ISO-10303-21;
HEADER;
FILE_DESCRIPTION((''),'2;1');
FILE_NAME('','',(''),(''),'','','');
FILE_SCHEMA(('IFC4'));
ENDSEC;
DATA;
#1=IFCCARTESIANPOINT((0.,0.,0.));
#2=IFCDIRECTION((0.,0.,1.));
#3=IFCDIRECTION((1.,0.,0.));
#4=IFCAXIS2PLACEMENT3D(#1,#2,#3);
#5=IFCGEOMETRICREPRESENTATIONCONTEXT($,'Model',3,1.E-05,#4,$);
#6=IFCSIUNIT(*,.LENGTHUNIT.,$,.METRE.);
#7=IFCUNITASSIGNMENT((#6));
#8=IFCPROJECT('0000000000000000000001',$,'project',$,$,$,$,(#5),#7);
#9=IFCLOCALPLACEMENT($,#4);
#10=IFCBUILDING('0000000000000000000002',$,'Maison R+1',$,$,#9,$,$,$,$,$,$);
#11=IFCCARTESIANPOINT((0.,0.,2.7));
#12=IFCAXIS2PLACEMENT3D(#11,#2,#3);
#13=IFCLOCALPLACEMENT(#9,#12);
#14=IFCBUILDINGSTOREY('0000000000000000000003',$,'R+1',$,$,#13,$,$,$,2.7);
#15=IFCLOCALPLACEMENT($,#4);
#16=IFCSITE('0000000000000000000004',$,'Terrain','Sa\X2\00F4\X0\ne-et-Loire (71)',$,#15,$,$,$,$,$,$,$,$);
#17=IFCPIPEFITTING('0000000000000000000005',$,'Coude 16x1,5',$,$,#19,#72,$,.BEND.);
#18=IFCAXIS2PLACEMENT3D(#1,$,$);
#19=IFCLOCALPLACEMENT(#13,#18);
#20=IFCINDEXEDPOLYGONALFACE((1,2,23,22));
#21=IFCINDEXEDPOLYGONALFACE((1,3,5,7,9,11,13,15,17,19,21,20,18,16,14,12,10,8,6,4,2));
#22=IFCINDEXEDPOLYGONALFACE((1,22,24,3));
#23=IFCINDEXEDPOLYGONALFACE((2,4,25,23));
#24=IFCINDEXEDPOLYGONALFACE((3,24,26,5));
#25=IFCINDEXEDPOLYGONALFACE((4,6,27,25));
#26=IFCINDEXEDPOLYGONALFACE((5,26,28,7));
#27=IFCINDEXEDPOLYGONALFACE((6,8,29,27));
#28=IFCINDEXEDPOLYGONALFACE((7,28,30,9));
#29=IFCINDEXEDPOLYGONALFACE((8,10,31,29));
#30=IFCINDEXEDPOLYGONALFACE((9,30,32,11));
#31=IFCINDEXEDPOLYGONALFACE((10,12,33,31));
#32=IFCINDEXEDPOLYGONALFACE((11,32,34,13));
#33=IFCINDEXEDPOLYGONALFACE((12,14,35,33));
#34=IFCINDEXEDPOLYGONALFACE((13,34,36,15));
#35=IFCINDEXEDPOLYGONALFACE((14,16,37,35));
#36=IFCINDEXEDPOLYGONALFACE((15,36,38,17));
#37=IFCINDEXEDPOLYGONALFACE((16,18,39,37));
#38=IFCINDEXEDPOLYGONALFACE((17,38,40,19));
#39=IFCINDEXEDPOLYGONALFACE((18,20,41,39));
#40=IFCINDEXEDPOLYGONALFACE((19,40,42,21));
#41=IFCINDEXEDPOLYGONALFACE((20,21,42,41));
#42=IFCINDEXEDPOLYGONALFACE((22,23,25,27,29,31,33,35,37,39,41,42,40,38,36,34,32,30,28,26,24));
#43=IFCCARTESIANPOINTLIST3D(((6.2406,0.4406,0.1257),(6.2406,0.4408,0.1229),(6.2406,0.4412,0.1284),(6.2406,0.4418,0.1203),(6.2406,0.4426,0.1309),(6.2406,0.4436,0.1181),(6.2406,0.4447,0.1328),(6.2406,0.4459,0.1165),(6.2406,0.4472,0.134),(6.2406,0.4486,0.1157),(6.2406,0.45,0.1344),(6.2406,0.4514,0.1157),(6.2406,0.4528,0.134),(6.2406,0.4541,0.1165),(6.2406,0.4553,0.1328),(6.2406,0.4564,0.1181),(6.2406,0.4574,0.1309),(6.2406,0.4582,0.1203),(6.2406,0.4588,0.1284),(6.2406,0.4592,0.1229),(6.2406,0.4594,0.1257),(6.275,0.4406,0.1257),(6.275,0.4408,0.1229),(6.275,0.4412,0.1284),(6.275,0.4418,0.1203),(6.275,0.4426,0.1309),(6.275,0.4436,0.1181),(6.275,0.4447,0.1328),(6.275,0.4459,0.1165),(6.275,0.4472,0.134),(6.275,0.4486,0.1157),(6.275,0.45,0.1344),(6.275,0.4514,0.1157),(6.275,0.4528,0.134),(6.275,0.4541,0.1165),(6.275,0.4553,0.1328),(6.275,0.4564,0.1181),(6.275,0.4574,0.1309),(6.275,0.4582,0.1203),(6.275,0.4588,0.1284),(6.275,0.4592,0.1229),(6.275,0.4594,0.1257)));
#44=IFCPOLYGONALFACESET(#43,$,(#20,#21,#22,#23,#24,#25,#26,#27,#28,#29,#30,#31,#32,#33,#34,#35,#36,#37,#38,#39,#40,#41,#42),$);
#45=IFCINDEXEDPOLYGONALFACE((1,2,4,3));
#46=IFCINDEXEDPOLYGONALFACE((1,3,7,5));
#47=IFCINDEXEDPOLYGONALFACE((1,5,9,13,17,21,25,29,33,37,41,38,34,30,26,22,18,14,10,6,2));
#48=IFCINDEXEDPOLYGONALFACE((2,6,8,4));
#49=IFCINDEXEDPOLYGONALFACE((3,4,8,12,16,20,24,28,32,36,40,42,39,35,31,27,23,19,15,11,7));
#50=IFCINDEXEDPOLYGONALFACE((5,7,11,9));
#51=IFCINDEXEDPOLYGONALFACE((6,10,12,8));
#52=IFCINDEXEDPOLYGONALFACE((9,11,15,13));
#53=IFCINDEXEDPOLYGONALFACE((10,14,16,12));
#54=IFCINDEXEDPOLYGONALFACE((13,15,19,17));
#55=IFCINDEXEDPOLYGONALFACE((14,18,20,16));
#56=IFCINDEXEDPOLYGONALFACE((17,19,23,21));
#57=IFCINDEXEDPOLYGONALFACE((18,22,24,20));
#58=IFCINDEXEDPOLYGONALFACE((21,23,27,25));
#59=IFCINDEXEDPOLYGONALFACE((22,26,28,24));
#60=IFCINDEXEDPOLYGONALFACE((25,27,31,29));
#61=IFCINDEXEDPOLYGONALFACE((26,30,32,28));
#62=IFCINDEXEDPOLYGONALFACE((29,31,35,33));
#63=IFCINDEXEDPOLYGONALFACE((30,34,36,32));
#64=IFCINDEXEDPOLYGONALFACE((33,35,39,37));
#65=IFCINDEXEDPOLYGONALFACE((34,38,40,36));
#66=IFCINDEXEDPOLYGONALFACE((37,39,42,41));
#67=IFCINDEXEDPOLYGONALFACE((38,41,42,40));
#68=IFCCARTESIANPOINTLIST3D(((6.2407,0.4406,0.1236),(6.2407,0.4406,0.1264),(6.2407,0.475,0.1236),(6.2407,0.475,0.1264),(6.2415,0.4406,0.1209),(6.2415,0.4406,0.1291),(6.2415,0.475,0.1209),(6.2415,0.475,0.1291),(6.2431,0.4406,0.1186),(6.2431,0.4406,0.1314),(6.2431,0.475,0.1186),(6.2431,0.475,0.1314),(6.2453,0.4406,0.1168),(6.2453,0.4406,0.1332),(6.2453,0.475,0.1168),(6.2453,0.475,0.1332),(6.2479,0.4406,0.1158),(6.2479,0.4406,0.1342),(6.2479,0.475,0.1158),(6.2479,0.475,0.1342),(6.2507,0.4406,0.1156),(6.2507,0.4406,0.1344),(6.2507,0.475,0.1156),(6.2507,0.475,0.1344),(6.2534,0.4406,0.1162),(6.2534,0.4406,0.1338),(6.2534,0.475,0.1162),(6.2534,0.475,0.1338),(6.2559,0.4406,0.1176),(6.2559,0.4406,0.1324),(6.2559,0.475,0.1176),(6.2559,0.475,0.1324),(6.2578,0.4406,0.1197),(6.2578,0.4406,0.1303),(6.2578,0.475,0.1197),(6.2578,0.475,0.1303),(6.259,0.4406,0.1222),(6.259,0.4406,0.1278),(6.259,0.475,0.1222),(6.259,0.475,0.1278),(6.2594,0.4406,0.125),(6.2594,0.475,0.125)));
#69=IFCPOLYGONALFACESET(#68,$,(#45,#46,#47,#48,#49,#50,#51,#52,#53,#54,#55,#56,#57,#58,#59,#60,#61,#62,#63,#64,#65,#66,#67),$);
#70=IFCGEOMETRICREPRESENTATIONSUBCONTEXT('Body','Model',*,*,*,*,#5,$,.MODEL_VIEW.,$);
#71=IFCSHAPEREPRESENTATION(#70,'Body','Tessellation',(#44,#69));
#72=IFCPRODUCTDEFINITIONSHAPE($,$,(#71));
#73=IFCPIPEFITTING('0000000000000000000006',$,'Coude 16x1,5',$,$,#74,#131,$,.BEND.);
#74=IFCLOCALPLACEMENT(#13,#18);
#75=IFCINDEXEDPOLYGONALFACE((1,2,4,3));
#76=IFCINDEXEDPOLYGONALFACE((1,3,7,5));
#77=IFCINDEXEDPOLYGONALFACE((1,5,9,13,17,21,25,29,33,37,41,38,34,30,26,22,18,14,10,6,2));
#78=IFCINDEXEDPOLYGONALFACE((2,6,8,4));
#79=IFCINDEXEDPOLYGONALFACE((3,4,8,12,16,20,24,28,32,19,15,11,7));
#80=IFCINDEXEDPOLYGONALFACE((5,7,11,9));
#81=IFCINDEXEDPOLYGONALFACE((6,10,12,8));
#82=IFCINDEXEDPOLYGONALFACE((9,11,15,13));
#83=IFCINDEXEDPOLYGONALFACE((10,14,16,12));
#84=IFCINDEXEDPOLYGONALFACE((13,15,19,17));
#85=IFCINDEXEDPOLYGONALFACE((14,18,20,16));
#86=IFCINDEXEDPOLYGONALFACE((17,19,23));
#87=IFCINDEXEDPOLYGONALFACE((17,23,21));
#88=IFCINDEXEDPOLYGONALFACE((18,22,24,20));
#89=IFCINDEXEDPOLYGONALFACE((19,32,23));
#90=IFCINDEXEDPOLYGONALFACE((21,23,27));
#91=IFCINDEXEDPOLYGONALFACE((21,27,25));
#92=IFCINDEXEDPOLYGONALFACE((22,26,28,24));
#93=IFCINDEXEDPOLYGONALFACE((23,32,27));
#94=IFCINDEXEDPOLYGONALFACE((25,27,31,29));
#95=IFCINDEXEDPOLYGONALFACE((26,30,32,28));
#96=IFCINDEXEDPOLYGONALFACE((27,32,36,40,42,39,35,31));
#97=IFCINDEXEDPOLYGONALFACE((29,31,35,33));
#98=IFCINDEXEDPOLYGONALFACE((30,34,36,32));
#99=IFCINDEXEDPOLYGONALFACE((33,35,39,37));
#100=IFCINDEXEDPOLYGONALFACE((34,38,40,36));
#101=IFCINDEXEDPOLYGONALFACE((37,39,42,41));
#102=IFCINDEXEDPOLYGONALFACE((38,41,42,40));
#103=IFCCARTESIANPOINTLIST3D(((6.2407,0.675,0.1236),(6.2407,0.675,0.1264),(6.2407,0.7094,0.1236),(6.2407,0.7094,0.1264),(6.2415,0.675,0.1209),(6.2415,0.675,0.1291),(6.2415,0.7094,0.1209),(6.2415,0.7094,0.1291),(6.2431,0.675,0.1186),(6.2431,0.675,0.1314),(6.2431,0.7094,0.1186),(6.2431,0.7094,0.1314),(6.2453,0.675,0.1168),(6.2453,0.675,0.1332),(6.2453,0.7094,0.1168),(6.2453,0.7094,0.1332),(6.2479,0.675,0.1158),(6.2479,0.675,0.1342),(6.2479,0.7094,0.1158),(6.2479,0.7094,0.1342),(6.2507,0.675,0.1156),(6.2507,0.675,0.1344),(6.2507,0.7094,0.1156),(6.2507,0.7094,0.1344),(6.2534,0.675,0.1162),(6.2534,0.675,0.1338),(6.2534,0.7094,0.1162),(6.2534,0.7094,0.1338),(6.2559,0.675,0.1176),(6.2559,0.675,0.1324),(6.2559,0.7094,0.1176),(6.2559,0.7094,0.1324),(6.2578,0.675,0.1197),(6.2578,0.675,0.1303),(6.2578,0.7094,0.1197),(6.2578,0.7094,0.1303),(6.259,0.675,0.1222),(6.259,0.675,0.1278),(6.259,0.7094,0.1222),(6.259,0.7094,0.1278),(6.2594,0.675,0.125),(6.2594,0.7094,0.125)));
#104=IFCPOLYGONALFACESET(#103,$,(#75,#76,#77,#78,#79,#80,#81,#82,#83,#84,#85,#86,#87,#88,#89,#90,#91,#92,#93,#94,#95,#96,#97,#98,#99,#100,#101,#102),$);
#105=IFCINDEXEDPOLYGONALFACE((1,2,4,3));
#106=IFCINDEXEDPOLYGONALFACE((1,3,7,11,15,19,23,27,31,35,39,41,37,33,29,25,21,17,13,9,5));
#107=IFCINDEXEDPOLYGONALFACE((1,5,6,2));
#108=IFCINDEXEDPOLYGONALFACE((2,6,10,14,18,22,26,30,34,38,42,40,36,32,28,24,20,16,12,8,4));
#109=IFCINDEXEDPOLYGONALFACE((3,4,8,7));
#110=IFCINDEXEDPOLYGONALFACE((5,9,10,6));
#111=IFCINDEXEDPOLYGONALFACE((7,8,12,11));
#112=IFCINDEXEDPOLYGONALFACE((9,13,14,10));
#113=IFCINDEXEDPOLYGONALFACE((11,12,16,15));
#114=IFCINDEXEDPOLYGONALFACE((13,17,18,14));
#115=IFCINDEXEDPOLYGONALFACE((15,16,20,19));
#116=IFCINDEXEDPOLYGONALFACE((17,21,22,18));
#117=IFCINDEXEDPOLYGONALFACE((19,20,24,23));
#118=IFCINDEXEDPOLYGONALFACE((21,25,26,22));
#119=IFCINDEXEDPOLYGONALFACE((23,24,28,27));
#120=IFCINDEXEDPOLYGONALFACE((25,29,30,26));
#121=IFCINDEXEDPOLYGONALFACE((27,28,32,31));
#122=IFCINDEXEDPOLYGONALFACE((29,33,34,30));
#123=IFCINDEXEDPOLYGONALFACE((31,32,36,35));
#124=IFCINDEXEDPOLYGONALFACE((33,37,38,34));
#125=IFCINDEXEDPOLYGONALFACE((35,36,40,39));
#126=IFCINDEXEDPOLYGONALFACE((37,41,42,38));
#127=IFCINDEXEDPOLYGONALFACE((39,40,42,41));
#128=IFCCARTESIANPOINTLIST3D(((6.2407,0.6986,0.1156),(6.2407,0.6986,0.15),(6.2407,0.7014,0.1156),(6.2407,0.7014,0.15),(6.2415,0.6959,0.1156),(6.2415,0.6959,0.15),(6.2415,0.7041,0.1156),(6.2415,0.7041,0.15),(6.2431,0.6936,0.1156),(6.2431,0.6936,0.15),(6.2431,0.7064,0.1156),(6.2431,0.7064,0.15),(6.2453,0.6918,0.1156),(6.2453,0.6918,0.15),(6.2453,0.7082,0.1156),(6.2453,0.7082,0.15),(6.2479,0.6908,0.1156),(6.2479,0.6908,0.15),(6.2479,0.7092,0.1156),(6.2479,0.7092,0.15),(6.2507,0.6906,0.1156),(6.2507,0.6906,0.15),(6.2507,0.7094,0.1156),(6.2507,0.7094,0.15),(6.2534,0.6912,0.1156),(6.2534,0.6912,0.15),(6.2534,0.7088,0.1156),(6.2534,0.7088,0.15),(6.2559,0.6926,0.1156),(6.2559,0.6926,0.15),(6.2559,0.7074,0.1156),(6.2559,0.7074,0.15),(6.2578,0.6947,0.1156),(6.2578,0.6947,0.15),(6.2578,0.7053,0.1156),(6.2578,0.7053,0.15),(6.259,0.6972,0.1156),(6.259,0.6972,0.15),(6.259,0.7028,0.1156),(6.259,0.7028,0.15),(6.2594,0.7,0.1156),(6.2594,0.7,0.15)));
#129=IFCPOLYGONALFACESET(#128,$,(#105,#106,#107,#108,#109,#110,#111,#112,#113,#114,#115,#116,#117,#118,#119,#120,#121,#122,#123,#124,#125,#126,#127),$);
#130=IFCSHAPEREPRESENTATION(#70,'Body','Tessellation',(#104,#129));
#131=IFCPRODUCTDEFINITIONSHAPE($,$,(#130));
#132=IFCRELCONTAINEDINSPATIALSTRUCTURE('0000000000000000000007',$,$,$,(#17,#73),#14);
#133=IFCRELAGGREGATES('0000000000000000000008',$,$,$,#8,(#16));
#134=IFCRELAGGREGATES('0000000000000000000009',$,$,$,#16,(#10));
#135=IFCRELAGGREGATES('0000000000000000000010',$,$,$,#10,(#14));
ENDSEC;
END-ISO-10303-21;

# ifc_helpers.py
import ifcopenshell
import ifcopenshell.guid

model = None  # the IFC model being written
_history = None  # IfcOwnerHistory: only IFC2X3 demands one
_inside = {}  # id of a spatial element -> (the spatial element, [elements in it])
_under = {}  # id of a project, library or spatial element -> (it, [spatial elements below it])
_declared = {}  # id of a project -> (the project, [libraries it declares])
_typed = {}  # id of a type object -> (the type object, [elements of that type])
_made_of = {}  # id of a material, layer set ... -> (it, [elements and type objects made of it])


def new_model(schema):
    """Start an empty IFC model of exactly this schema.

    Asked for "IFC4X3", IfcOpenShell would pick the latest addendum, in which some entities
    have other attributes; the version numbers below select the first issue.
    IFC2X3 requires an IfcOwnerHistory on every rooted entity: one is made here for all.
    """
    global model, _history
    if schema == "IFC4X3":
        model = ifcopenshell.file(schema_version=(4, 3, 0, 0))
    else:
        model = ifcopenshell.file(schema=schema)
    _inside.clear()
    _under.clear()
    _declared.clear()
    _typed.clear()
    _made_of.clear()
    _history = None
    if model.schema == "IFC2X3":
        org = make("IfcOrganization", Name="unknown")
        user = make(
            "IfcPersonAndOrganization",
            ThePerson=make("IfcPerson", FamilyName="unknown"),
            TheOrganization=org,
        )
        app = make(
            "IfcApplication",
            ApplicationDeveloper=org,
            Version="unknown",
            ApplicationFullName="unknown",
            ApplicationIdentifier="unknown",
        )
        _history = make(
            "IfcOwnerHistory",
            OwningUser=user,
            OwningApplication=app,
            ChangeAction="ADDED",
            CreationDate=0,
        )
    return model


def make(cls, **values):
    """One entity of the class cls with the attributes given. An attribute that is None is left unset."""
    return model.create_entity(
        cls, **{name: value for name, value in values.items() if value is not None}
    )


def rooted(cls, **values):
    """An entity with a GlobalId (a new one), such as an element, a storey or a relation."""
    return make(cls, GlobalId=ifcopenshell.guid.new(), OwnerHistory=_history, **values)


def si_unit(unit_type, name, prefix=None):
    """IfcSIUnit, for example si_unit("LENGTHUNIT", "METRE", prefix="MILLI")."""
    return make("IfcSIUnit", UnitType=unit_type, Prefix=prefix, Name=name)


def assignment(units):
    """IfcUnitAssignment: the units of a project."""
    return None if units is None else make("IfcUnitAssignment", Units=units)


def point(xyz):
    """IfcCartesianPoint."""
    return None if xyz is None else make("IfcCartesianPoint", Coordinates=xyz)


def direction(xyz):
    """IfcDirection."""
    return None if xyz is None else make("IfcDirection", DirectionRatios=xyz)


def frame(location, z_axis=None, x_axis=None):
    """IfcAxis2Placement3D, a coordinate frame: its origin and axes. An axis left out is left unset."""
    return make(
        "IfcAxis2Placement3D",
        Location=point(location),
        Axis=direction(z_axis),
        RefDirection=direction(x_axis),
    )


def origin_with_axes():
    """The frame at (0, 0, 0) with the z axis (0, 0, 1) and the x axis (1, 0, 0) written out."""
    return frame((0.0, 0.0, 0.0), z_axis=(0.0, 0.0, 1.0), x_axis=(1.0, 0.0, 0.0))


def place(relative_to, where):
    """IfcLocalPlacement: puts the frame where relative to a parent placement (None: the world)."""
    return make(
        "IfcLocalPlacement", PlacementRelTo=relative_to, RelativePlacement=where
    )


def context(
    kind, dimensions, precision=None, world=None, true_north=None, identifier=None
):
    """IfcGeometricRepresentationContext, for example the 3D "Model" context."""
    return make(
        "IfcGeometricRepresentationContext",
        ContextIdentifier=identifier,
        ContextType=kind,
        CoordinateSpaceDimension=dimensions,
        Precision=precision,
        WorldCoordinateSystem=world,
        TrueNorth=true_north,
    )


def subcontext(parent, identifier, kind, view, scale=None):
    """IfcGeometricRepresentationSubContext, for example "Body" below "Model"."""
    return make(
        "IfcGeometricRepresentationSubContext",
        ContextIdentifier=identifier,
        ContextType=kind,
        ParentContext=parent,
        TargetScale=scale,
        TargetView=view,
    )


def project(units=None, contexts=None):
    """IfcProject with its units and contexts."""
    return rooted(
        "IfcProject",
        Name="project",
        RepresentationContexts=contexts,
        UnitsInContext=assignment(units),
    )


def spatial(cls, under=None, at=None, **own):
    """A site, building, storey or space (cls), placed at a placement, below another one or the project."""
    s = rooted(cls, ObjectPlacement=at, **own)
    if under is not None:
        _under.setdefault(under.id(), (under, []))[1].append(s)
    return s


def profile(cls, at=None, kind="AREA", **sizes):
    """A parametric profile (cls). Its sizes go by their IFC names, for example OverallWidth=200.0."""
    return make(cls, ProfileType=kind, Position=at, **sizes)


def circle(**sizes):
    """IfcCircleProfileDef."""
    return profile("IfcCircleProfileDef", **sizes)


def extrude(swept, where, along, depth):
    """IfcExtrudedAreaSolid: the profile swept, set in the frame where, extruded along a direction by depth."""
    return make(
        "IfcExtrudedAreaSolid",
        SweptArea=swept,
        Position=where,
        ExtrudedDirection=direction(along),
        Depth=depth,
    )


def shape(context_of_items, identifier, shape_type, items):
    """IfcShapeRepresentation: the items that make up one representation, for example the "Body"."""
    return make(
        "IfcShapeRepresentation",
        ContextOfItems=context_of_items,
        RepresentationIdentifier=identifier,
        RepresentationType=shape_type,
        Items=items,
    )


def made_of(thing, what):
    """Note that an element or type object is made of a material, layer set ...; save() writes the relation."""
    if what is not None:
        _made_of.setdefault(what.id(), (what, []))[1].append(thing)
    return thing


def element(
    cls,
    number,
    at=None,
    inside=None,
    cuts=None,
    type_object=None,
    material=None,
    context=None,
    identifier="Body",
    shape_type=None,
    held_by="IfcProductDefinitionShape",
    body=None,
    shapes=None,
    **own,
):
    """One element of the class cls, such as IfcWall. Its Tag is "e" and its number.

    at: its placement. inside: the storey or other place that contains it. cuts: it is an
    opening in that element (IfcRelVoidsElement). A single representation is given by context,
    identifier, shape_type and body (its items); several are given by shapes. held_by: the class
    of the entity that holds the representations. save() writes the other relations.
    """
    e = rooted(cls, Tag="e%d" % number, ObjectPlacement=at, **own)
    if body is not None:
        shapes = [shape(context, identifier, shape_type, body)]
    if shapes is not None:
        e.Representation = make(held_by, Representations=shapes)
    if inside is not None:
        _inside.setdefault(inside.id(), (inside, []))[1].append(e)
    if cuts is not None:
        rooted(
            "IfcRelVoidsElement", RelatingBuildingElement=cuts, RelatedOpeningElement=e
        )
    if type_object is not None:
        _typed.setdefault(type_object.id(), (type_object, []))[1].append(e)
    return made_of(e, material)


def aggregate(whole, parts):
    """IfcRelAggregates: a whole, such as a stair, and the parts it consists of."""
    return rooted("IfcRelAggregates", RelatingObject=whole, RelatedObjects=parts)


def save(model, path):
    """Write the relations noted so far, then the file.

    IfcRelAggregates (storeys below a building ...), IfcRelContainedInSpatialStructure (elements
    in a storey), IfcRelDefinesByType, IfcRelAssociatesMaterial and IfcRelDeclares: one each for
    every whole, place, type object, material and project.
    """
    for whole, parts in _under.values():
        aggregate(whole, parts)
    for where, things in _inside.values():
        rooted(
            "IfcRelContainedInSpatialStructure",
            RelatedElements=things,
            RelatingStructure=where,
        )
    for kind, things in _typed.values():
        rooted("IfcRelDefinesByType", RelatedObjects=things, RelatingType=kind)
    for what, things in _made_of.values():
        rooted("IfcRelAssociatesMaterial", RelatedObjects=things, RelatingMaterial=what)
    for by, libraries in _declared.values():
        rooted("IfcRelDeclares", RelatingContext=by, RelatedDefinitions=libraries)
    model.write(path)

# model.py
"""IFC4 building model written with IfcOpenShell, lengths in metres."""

from ifc_helpers import new_model, si_unit, frame, origin_with_axes, place, context, subcontext, project, spatial, circle, extrude, element, save


model = new_model("IFC4")

# Units and contexts
model_context = context("Model", 3, precision=1e-05, world=origin_with_axes())
body_context = subcontext(model_context, "Body", "Model", "MODEL_VIEW")
ifc_project = project(units=[si_unit("LENGTHUNIT", "METRE")], contexts=[model_context])

# Site, building, storey
site_placement = place(None, origin_with_axes())
site = spatial("IfcSite", under=ifc_project, at=site_placement, Name="Terrain", Description="Saône-et-Loire (71)")
building_placement = place(None, origin_with_axes())
building = spatial("IfcBuilding", under=site, at=building_placement, Name="Maison R+1")
storey_placement = place(building_placement, frame((0.0, 0.0, 2.7), z_axis=(0.0, 0.0, 1.0), x_axis=(1.0, 0.0, 0.0)))
storey = spatial("IfcBuildingStorey", under=building, at=storey_placement, Name="R+1", Elevation=2.7)

# Pipe fittings
pipe_fitting_1_placement = place(storey_placement, frame((6.25, 0.45, 0.125), z_axis=(0.0, 0.0, 1.0), x_axis=(1.0, 0.0, 0.0)))
element("IfcPipeFitting", 1, at=pipe_fitting_1_placement, inside=storey, Name="Coude 16x1,5", PredefinedType="BEND", context=body_context, shape_type="SweptSolid", body=[
    extrude(circle(Radius=0.0094), frame((-0.0094, 0.0, 0.0), z_axis=(1.0, 0.0, 0.0), x_axis=(0.0, 0.0, 1.0)), (0.0, 0.0, 1.0), 0.0344),
    extrude(circle(Radius=0.0094), frame((0.0, -0.0094, 0.0), z_axis=(0.0, 1.0, 0.0), x_axis=(1.0, 0.0, 0.0)), (0.0, 0.0, 1.0), 0.0344),
])
pipe_fitting_2_placement = place(storey_placement, frame((6.25, 0.7, 0.125), z_axis=(0.0, 0.0, 1.0), x_axis=(1.0, 0.0, 0.0)))
element("IfcPipeFitting", 2, at=pipe_fitting_2_placement, inside=storey, Name="Coude 16x1,5", PredefinedType="BEND", context=body_context, shape_type="SweptSolid", body=[
    extrude(circle(Radius=0.0094), frame((0.0, 0.0094, 0.0), z_axis=(0.0, -1.0, 0.0), x_axis=(1.0, 0.0, 0.0)), (0.0, 0.0, 1.0), 0.0344),
    extrude(circle(Radius=0.0094), frame((0.0, 0.0, -0.0094), z_axis=(0.0, 0.0, 1.0), x_axis=(1.0, 0.0, 0.0)), (0.0, 0.0, 1.0), 0.0344),
])

save(model, "model.ifc")
